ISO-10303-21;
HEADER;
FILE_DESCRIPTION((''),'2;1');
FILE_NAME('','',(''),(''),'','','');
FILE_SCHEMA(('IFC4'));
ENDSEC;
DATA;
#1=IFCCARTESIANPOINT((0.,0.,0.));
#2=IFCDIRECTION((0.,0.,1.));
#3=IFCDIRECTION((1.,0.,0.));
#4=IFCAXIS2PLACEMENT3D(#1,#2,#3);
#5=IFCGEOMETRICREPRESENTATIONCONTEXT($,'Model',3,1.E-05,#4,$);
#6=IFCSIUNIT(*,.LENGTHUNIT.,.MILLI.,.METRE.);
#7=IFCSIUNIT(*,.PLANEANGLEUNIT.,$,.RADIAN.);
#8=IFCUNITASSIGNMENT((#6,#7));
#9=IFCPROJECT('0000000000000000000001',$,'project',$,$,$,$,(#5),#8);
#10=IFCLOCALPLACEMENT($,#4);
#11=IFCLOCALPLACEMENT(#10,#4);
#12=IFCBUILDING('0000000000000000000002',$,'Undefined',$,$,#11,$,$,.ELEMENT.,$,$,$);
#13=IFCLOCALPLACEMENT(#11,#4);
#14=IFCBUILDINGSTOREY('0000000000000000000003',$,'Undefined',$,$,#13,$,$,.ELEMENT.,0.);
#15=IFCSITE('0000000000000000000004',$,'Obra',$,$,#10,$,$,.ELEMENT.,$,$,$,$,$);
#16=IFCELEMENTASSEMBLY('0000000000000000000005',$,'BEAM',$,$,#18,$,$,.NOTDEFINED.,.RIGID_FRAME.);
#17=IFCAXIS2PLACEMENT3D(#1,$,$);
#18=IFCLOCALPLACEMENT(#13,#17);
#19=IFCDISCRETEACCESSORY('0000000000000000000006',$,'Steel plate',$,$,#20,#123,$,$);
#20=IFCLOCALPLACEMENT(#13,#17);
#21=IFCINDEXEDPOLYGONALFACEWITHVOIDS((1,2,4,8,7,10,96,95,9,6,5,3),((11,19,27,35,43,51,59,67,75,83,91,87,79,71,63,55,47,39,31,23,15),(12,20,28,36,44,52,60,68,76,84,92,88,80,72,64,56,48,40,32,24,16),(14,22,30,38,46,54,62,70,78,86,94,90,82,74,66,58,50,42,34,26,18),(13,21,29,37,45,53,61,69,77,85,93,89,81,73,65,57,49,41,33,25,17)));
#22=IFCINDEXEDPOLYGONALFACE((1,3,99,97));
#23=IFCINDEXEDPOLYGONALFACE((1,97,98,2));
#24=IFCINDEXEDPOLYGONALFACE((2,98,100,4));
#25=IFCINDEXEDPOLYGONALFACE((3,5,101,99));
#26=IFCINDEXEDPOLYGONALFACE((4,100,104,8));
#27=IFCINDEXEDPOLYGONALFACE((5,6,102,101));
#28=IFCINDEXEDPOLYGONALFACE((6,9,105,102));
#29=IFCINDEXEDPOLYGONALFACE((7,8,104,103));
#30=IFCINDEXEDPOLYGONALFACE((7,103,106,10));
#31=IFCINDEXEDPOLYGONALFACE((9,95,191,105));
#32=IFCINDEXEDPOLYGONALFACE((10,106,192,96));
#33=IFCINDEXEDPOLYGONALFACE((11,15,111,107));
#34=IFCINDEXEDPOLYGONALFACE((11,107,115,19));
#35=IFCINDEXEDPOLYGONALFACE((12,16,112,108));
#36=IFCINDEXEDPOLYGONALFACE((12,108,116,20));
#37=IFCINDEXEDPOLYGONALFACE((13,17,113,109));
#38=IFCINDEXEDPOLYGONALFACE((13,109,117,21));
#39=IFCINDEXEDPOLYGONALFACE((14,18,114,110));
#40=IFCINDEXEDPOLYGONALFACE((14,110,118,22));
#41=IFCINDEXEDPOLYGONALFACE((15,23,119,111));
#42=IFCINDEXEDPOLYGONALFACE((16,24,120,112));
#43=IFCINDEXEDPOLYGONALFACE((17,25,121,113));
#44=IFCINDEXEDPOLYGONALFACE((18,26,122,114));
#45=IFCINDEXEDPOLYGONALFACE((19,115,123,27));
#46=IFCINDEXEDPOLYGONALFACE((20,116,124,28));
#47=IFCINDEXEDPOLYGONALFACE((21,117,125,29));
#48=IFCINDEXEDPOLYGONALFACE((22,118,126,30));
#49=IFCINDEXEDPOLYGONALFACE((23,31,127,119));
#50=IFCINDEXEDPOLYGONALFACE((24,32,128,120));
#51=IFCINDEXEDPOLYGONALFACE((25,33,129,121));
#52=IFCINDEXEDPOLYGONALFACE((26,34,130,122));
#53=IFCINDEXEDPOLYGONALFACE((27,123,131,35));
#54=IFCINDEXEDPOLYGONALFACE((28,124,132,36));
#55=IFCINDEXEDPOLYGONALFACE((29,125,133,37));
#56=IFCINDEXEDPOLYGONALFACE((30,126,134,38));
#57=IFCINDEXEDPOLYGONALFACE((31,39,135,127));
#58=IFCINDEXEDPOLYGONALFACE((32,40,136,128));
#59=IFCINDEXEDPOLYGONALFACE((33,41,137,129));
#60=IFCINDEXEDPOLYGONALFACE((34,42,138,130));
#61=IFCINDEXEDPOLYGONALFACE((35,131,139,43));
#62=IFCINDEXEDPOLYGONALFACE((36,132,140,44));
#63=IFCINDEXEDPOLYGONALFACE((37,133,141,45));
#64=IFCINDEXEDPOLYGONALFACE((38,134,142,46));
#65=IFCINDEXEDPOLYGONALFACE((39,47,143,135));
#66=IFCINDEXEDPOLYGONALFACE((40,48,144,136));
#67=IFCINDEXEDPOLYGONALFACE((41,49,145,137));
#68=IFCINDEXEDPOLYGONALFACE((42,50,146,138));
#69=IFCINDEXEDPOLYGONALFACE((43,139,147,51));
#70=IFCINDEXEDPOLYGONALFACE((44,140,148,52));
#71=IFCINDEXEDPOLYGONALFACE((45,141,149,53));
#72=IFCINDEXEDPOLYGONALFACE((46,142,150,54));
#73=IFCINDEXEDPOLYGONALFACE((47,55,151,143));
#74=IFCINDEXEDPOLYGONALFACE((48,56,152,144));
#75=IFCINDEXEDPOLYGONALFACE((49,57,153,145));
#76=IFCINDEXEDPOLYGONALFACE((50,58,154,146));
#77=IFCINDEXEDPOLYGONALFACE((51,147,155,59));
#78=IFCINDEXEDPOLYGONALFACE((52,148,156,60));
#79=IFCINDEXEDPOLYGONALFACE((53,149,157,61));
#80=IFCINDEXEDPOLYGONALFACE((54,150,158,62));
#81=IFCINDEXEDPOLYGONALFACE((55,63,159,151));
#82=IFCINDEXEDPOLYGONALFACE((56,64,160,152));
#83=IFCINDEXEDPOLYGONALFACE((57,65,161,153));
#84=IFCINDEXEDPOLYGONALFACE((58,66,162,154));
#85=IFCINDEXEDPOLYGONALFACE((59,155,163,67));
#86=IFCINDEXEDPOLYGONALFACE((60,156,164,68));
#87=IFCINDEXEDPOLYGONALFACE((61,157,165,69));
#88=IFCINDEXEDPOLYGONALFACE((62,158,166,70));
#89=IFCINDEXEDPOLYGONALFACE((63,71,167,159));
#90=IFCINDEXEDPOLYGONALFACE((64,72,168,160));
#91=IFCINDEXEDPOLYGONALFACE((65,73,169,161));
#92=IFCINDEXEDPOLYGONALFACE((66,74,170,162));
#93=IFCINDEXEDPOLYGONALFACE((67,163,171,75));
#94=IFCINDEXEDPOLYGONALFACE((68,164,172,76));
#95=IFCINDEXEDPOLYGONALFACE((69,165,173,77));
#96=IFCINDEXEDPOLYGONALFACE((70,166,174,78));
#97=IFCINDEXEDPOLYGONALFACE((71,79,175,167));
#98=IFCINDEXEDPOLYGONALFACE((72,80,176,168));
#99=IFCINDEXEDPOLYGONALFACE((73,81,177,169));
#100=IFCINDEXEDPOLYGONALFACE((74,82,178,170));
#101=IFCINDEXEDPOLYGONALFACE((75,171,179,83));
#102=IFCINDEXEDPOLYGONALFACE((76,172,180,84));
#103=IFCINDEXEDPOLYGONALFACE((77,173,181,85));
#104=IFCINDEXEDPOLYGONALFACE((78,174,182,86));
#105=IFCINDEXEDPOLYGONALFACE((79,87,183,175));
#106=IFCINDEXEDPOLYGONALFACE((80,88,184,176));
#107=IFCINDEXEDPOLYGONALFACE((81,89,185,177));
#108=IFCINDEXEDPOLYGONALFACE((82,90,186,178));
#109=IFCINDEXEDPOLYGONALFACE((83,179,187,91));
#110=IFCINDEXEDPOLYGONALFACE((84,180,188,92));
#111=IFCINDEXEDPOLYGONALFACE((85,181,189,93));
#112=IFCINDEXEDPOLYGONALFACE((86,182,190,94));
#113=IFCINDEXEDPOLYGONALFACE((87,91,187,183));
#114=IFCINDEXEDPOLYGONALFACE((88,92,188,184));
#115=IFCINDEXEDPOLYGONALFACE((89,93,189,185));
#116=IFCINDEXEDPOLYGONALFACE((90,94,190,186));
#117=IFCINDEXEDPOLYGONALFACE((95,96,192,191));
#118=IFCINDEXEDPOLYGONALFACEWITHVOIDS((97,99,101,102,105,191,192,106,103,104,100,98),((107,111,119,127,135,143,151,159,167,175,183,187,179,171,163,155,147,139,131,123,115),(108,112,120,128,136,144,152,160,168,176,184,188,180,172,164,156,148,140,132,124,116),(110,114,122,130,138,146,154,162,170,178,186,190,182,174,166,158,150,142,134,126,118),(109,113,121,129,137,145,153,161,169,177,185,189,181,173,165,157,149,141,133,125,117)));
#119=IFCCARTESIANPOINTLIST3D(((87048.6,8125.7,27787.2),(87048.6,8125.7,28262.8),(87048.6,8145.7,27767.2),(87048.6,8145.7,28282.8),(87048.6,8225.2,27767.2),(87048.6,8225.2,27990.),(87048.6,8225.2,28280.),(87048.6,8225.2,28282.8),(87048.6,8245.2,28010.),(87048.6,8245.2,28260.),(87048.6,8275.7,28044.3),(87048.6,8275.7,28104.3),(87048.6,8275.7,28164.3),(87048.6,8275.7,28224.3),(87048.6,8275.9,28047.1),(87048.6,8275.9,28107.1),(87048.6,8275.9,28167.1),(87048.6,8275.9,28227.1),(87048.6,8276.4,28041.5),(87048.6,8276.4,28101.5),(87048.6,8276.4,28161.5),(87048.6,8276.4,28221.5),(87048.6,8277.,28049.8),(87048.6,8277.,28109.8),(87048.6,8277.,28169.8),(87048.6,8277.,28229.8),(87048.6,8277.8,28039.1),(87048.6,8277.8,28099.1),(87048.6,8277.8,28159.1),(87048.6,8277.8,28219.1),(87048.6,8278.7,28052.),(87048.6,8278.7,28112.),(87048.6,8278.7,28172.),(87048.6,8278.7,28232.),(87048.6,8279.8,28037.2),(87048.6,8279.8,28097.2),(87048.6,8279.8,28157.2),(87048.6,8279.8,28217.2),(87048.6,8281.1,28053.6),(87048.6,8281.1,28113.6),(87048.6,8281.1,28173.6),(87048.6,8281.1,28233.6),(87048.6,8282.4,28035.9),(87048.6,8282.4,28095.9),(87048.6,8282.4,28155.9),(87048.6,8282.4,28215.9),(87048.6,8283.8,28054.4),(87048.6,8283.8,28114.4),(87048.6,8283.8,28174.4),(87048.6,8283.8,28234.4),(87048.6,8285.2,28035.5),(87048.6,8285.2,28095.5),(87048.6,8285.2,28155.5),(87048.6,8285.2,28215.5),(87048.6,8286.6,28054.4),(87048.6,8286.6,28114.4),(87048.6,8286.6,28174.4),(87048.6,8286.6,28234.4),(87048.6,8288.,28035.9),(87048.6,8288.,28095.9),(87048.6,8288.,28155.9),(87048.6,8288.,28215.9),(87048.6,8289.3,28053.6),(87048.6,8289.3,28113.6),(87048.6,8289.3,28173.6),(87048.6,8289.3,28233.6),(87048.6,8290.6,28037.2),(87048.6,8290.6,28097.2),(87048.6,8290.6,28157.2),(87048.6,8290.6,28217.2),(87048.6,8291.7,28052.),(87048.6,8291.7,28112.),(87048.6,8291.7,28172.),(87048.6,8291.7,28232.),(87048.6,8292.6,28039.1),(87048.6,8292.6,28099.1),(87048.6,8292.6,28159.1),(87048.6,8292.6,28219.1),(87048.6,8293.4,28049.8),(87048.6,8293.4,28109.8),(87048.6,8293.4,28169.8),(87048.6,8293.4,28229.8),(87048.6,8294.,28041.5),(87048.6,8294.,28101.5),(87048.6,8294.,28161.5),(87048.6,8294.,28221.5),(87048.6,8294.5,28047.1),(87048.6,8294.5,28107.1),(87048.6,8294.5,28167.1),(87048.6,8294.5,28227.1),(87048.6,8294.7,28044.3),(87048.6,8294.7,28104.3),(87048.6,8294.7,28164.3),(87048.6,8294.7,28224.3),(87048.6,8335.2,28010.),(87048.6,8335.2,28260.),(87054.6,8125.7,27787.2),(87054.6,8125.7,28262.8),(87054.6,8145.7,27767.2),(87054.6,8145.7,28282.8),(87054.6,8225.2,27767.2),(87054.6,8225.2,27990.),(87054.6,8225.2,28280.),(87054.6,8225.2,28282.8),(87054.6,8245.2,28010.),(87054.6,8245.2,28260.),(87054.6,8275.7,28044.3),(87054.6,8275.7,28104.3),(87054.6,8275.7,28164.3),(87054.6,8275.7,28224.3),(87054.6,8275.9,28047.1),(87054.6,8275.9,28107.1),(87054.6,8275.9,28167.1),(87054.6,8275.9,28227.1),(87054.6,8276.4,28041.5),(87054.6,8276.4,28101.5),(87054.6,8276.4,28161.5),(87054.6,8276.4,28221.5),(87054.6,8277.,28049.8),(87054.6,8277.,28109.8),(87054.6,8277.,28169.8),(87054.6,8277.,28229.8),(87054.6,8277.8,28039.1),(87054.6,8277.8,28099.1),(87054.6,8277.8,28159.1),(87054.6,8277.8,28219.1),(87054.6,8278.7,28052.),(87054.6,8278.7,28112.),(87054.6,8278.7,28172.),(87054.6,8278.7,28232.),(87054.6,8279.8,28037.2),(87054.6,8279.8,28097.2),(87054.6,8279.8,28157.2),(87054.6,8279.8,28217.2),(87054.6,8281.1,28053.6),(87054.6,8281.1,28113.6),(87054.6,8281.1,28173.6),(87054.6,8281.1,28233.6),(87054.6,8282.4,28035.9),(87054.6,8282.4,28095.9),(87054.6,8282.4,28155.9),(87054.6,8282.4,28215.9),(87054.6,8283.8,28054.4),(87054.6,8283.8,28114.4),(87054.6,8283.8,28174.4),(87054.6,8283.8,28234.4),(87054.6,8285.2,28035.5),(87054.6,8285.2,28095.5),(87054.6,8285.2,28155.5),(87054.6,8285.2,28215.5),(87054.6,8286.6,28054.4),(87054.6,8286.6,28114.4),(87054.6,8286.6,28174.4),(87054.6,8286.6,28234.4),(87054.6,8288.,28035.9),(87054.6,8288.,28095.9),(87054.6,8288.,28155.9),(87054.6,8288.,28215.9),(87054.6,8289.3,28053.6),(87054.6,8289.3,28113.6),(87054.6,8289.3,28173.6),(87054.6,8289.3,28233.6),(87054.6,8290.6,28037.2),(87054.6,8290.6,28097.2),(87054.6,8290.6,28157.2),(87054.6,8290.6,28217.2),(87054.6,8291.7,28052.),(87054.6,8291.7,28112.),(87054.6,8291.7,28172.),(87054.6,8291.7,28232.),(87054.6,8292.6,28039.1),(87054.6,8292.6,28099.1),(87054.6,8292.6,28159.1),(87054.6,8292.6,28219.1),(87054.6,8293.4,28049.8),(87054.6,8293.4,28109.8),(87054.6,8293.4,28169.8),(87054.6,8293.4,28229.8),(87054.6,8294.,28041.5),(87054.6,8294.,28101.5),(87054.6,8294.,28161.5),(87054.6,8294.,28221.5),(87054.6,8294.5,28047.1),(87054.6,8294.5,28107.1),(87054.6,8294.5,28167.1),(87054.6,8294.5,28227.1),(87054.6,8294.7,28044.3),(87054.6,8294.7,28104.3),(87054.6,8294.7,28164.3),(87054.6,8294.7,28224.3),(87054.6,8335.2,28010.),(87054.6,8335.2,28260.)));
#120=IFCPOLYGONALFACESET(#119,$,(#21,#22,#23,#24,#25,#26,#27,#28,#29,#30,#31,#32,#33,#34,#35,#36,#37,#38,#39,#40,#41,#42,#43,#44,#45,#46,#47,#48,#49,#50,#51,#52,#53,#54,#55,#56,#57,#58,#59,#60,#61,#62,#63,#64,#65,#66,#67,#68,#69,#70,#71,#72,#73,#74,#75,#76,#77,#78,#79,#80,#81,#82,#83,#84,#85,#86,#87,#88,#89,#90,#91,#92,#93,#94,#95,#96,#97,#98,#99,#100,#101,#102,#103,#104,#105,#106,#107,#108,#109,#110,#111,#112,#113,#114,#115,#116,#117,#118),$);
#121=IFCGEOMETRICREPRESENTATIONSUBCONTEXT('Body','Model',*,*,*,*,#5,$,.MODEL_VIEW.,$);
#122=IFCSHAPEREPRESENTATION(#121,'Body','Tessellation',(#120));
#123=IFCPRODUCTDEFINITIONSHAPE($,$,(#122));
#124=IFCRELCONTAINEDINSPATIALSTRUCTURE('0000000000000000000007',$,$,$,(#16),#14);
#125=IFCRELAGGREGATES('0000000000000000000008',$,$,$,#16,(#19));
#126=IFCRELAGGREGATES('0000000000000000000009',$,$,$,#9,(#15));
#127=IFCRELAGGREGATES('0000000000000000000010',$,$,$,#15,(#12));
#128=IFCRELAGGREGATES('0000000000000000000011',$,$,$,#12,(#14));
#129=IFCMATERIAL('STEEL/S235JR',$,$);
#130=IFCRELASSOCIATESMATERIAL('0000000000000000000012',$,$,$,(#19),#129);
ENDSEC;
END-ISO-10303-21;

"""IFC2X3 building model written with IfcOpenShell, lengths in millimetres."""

from ifc_helpers import new_model, si_unit, frame, origin_with_axes, origin_2d_with_axis, place, context, subcontext, project, spatial, polyline, circle, outline, extrude, source, transform, mapped, material, element, aggregate, save


model = new_model("IFC2X3")

# Units and contexts
model_context = context("Model", 3, precision=1e-05, world=origin_with_axes())
body_context = subcontext(model_context, "Body", "Model", "MODEL_VIEW")
ifc_project = project(units=[si_unit("LENGTHUNIT", "METRE", prefix="MILLI"), si_unit("PLANEANGLEUNIT", "RADIAN")], contexts=[model_context])

# Site, building, storey
site_placement = place(None, origin_with_axes())
site = spatial("IfcSite", under=ifc_project, at=site_placement, Name="Obra", CompositionType="ELEMENT")
building_placement = place(site_placement, origin_with_axes())
building = spatial("IfcBuilding", under=site, at=building_placement, Name="Undefined", CompositionType="ELEMENT")
storey_placement = place(building_placement, origin_with_axes())
storey = spatial("IfcBuildingStorey", under=building, at=storey_placement, Name="Undefined", CompositionType="ELEMENT", Elevation=0.0)

# Shared definitions
ifc_material = material(Name="STEEL/S235JR")

# Element assembly, discrete accessory, opening
assembly_1_placement = place(storey_placement, origin_with_axes())
assembly_1 = element("IfcElementAssembly", 1, at=assembly_1_placement, inside=storey, Name="BEAM", AssemblyPlace="NOTDEFINED", PredefinedType="RIGID_FRAME")
discrete_accessory_1_placement = place(assembly_1_placement, frame((87051.6, 8125.7, 27787.2), z_axis=(1.0, -0.000001, 0.0), x_axis=(0.000001, 0.707107, -0.707107)))
discrete_accessory_1 = element("IfcDiscreteAccessory", 2, at=discrete_accessory_1_placement, material=ifc_material, Name="Steel plate", context=body_context, shape_type="SweptSolid", body=[
    extrude(outline(polyline([(0.0, 0.0), (28.3, 0.0), (84.5, 56.2), (-73.1, 213.7), (-73.1, 242.0), (-9.4, 305.6), (-186.2, 482.4), (-249.9, 418.8), (-278.1, 418.8), (-280.1, 420.8), (-336.3, 364.6), (-336.3, 336.3), (0.0, 0.0)])), frame((0.0, 0.0, -3.0), z_axis=(0.0, 0.0, 1.0), x_axis=(1.0, 0.0, 0.0)), (0.0, 0.0, 1.0), 6.0),
])
shared_shape_1 = source(origin_with_axes(), body_context, "Body", "SweptSolid", [
    extrude(circle(Radius=9.5, at=origin_2d_with_axis()), frame((0.0, -9.8, 0.0), z_axis=(0.0, 1.0, 0.0), x_axis=(1.0, 0.0, 0.0)), (0.0, 0.0, 1.0), 6.2),
])
opening_1_placement = place(assembly_1_placement, frame((87044.8, 8235.2, 28260.0), z_axis=(0.000001, 1.0, 0.0), x_axis=(0.0, 0.0, -1.0)))
element("IfcOpeningElement", 3, at=opening_1_placement, cuts=discrete_accessory_1, ObjectType="Opening", context=body_context, shape_type="MappedRepresentation", body=[
    mapped(shared_shape_1, transform((35.0, 0.0, 50.0))),
    mapped(shared_shape_1, transform((95.0, 0.0, 50.0))),
    mapped(shared_shape_1, transform((155.0, 0.0, 50.0))),
    mapped(shared_shape_1, transform((215.0, 0.0, 50.0))),
])
aggregate(assembly_1, [discrete_accessory_1])

save(model, "model.ifc")
